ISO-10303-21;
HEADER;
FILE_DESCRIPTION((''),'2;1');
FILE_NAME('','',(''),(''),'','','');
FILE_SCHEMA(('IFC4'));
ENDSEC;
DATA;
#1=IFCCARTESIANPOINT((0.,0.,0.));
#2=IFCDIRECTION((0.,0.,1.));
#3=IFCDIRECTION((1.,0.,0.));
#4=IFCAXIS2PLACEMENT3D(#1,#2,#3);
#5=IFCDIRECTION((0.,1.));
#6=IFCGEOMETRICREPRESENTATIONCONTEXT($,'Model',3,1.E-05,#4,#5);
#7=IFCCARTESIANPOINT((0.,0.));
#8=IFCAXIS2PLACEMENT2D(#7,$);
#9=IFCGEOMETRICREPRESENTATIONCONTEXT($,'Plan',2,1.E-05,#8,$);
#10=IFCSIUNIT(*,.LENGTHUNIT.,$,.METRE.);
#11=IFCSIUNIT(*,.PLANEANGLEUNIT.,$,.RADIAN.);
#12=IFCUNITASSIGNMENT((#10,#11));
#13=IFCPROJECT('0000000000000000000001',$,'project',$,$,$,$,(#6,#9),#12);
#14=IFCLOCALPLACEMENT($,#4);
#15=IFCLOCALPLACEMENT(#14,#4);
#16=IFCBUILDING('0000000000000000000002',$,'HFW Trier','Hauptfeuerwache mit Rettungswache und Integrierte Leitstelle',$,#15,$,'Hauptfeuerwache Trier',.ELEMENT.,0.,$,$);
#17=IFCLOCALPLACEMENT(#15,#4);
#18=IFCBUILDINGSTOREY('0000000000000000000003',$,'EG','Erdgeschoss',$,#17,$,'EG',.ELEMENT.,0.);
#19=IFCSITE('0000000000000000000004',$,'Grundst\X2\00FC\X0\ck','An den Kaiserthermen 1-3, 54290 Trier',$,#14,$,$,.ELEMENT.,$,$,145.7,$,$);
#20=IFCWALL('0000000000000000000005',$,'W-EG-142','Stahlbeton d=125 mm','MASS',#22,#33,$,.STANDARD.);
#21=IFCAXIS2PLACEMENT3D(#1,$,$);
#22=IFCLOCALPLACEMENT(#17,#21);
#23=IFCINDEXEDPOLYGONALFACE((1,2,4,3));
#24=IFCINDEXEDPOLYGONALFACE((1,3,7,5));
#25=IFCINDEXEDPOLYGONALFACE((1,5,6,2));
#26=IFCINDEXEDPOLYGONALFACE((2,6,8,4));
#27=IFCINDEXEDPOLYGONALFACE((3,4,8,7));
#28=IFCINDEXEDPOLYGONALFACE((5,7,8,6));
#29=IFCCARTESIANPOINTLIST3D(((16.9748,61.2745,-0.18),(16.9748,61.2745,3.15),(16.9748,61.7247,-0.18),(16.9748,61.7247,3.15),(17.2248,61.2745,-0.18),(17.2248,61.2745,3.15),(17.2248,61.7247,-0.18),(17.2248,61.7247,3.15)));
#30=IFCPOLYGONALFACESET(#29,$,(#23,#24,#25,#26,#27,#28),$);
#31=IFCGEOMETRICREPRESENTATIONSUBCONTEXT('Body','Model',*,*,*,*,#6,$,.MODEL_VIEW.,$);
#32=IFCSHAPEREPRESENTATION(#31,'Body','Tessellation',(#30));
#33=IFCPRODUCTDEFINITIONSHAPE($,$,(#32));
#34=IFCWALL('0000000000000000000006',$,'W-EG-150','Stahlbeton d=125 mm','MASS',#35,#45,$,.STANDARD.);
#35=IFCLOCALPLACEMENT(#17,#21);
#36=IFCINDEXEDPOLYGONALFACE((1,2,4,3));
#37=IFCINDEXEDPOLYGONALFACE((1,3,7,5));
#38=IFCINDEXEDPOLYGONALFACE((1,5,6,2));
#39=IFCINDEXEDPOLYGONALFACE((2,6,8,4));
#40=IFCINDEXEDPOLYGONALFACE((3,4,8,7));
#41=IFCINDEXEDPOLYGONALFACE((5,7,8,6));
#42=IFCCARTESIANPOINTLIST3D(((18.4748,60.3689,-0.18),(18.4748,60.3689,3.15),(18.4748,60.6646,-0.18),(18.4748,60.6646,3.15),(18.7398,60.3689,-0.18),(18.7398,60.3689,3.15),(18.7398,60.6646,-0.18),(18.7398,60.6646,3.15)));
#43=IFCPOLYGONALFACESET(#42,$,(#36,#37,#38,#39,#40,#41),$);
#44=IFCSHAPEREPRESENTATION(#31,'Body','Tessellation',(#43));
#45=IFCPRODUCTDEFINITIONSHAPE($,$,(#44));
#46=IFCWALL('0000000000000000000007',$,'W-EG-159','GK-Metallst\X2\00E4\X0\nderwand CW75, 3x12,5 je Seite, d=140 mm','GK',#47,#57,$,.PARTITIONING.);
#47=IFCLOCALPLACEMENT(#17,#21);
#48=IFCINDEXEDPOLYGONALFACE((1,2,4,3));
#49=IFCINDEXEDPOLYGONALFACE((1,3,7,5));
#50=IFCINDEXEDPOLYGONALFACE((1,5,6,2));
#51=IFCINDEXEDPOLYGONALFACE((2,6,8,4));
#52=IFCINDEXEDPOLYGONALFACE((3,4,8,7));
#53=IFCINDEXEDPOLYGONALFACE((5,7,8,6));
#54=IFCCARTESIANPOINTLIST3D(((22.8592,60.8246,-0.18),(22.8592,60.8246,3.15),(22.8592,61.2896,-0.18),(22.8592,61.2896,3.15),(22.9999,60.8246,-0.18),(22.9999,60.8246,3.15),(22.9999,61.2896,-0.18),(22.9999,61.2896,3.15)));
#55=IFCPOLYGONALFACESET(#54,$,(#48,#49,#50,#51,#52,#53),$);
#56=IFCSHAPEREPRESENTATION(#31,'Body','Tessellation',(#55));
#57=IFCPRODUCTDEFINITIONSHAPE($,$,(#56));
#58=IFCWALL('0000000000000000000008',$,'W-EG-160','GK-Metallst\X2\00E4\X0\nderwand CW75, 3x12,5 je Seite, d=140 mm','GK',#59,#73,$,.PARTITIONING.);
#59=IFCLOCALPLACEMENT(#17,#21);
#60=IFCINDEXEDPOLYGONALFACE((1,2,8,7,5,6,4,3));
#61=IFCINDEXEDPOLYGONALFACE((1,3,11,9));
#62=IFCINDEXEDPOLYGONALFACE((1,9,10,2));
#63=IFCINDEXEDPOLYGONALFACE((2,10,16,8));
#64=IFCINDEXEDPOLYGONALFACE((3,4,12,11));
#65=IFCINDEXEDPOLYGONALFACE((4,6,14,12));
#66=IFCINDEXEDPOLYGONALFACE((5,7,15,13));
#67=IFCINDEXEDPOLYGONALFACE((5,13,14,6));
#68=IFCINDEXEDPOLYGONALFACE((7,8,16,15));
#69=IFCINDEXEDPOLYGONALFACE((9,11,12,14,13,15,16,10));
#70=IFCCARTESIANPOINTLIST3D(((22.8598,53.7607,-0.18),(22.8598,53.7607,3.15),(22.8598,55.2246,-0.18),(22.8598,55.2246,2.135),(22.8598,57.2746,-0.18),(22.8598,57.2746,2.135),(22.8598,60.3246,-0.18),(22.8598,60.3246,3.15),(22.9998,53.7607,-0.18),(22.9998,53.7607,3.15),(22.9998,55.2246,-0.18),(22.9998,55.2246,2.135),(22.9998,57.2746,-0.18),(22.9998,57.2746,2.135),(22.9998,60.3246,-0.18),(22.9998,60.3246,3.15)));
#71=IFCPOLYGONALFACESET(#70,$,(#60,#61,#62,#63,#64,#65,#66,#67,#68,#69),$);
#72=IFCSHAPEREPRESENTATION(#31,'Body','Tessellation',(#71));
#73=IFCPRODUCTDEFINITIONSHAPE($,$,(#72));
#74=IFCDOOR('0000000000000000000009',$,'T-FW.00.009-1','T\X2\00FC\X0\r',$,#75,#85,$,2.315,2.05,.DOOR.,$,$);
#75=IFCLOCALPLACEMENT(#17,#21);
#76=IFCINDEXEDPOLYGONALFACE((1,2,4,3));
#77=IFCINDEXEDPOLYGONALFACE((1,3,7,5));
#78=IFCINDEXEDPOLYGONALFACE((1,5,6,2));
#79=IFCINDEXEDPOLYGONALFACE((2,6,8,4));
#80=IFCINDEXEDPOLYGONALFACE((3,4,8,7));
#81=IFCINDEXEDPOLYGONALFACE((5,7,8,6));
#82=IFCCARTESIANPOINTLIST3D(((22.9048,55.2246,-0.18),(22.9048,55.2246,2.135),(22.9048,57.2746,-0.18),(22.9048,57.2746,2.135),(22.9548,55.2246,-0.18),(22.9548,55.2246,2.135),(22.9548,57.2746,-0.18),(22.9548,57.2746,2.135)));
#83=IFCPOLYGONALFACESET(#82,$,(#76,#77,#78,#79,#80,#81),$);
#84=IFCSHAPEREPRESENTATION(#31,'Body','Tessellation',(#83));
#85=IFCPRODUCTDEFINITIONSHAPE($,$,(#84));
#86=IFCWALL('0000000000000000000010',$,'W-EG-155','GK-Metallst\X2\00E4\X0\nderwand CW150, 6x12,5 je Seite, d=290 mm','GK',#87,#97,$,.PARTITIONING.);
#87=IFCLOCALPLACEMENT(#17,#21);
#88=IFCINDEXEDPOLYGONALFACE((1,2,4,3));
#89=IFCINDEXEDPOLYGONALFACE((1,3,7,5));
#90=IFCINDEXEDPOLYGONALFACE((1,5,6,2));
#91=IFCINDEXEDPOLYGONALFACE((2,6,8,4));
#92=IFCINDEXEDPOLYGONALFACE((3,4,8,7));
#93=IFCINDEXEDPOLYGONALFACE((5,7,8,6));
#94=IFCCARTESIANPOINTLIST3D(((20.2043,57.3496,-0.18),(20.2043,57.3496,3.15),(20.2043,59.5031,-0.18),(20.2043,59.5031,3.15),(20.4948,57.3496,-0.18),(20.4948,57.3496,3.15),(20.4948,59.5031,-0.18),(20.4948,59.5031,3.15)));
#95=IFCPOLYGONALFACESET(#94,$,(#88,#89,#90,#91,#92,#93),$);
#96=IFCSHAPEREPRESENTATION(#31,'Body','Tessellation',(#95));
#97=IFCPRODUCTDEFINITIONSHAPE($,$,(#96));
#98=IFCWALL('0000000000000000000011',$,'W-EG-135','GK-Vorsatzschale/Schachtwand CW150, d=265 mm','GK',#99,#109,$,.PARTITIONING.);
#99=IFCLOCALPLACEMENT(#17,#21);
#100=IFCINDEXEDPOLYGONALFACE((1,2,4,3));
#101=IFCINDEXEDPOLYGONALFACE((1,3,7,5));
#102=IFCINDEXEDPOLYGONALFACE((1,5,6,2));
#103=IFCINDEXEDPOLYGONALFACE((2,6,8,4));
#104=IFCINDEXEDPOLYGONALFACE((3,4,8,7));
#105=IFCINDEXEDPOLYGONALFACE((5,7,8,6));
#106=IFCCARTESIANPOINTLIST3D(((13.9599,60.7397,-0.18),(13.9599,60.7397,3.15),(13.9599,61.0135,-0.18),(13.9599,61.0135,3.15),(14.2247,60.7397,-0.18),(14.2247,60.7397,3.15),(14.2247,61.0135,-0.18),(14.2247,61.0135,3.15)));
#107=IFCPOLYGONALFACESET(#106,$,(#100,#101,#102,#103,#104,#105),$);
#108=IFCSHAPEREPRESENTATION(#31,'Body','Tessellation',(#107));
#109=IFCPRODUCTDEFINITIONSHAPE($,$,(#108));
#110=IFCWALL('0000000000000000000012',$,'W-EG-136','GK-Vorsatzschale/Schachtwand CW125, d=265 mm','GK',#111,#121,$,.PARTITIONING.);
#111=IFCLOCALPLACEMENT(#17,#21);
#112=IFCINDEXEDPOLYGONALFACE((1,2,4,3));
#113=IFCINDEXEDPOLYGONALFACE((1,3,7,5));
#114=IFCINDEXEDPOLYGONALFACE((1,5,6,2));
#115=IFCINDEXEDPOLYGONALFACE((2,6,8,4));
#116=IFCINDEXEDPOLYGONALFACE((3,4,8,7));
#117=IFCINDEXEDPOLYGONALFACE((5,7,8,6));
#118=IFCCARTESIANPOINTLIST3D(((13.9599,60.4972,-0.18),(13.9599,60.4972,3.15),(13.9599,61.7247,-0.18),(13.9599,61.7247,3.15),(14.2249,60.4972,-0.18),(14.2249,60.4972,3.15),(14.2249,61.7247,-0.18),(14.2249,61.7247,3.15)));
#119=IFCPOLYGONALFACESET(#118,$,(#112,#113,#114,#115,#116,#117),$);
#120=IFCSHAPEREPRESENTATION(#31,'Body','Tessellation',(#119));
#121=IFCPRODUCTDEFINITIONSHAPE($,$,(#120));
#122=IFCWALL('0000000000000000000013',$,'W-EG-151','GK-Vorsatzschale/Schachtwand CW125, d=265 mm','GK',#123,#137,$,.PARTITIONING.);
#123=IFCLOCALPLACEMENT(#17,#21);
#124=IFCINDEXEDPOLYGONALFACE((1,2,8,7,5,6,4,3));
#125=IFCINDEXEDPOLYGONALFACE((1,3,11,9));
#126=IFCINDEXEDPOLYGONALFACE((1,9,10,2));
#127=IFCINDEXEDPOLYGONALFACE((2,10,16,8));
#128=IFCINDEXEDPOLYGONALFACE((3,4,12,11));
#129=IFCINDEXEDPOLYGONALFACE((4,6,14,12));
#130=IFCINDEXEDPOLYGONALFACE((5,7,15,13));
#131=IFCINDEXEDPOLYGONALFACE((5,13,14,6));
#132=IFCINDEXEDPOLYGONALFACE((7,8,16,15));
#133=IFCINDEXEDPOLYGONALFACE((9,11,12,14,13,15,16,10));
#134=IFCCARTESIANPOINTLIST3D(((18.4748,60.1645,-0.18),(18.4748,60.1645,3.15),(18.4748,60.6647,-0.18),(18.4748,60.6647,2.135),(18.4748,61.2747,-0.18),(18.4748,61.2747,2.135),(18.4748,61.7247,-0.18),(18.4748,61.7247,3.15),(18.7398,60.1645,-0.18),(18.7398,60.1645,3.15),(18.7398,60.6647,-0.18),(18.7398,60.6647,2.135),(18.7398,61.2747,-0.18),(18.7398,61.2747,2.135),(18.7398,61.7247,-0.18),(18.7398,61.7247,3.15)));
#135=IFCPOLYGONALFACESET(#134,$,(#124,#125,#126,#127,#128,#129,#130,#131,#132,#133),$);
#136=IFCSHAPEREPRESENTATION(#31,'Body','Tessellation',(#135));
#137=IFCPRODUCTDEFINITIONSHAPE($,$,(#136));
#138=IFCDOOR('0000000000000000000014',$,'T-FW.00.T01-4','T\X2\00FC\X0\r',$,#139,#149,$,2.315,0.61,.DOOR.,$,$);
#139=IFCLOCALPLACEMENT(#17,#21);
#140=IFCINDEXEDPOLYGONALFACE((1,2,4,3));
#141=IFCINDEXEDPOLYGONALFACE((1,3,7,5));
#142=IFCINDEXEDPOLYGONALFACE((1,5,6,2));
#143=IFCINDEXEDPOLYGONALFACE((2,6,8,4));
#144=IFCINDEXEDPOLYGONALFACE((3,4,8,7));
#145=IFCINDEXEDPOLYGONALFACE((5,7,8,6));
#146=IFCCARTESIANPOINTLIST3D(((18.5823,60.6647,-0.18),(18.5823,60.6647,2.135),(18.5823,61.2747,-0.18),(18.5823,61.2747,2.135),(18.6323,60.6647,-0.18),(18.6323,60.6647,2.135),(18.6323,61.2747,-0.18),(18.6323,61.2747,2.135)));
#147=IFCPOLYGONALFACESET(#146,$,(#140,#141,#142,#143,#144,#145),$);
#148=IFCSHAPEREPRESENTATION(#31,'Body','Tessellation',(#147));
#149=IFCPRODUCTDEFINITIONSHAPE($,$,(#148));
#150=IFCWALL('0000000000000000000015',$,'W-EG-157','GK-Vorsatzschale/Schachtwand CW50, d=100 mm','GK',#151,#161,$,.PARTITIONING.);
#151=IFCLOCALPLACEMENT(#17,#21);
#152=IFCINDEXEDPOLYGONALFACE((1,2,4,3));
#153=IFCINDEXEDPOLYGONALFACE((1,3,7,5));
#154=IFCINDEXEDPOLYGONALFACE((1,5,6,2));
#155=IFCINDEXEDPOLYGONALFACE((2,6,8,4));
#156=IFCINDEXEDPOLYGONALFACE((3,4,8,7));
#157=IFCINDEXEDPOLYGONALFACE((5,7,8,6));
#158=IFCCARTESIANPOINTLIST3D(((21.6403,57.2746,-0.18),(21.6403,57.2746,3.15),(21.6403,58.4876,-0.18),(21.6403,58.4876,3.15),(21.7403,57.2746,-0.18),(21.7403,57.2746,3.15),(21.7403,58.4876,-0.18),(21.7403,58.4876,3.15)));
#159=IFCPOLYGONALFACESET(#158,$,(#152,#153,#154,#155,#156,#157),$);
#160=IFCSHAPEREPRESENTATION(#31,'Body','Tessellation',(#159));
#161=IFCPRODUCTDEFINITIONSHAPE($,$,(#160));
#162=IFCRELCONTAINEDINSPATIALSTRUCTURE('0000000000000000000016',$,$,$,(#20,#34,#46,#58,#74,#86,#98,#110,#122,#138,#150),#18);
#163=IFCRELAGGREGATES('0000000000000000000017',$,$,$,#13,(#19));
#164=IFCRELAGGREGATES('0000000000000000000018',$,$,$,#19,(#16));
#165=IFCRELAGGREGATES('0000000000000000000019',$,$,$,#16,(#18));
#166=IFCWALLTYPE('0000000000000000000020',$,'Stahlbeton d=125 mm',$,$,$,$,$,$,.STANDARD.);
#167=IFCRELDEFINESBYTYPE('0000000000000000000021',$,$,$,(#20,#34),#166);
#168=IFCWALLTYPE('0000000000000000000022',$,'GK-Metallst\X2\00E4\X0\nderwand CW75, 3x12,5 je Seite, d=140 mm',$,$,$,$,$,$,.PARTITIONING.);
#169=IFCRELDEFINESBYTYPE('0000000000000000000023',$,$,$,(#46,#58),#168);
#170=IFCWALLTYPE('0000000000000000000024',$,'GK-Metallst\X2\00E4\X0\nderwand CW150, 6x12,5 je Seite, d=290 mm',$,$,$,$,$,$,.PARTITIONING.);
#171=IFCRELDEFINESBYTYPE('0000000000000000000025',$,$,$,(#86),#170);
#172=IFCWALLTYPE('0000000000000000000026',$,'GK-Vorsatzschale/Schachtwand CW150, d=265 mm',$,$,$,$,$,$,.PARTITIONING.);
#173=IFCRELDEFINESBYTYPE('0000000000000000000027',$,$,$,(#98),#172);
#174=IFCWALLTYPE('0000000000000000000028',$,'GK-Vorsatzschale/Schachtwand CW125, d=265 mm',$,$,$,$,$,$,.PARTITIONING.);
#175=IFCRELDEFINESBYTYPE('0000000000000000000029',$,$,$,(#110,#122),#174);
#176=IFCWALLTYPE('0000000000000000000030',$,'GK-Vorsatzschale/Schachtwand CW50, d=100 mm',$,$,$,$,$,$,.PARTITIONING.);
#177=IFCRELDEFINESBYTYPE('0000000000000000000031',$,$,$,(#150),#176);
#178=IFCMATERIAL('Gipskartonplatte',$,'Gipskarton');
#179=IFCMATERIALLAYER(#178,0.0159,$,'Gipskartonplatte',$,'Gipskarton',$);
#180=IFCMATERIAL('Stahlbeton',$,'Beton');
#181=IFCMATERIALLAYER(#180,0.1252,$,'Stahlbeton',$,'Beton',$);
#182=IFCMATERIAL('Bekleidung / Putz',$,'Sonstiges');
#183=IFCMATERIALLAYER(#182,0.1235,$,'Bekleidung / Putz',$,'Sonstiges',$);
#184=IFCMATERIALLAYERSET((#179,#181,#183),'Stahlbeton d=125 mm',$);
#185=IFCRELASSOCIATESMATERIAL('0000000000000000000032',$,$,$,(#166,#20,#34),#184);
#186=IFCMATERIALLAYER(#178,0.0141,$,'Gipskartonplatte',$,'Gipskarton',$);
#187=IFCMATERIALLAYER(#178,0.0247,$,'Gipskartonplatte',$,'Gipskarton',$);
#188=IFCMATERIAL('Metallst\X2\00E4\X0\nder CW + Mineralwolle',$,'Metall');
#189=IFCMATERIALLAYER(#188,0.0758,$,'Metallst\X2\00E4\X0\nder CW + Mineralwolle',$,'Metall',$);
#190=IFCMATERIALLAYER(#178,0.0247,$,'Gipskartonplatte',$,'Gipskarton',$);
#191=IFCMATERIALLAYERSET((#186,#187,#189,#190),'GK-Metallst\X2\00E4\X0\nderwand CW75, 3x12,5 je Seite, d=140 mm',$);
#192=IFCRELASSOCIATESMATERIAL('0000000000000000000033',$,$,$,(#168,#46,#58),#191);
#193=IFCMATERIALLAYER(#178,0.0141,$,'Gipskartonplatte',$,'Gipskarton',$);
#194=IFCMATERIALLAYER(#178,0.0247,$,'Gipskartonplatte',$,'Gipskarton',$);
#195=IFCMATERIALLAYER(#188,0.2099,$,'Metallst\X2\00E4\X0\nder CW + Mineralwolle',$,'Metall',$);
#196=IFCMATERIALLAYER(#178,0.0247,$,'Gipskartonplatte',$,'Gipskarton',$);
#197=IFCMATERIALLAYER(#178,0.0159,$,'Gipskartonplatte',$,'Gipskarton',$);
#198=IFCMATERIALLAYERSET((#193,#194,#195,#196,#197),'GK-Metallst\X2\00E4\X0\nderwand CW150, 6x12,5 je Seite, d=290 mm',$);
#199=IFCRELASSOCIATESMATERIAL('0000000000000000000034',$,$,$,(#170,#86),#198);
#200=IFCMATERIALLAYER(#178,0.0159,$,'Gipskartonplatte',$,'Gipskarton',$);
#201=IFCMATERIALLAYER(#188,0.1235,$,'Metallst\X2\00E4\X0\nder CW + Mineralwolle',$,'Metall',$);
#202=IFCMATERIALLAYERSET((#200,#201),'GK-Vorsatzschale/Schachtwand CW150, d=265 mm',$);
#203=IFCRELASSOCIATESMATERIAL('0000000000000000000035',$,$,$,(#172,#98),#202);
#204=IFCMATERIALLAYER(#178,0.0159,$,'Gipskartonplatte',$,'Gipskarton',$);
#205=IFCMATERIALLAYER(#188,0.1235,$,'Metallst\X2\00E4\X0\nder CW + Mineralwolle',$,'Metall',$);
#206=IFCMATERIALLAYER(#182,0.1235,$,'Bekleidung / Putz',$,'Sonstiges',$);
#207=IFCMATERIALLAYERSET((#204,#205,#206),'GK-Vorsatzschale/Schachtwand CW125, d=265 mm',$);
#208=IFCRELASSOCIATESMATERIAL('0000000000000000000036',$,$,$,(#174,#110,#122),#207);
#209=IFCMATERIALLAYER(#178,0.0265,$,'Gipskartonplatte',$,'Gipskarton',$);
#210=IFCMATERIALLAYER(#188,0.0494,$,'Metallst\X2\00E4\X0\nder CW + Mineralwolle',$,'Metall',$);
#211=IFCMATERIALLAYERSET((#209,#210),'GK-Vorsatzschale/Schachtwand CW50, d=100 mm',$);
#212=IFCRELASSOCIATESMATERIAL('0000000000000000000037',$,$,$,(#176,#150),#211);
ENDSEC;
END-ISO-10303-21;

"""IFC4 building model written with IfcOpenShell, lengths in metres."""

from ifc_helpers import new_model, si_unit, direction, frame, frame_2d, origin_with_axes, origin_2d, place, context, subcontext, project, spatial, rectangle, extrude, material, layer, layer_set, layer_usage, type_object, element, fill, save


model = new_model("IFC4")

# Units and contexts
model_context = context("Model", 3, precision=1e-05, world=origin_with_axes(), true_north=direction((0.0, 1.0)))
plan_context = context("Plan", 2, precision=1e-05, world=origin_2d())
body_context = subcontext(model_context, "Body", "Model", "MODEL_VIEW")
ifc_project = project(units=[si_unit("LENGTHUNIT", "METRE"), si_unit("PLANEANGLEUNIT", "RADIAN")], contexts=[model_context, plan_context])

# Site, building, storey
site_placement = place(None, origin_with_axes())
site = spatial("IfcSite", under=ifc_project, at=site_placement, Name="Grundstück", Description="An den Kaiserthermen 1-3, 54290 Trier", CompositionType="ELEMENT", RefElevation=145.7)
building_placement = place(site_placement, origin_with_axes())
building = spatial("IfcBuilding", under=site, at=building_placement, Name="HFW Trier", Description="Hauptfeuerwache mit Rettungswache und Integrierte Leitstelle", LongName="Hauptfeuerwache Trier", CompositionType="ELEMENT", ElevationOfRefHeight=0.0)
storey_placement = place(building_placement, origin_with_axes())
storey = spatial("IfcBuildingStorey", under=building, at=storey_placement, Name="EG", Description="Erdgeschoss", LongName="EG", CompositionType="ELEMENT", Elevation=0.0)

# Shared definitions
ifc_material_1 = material(Name="Stahlbeton", Category="Beton")

# Walls
ifc_material_2 = material(Name="Metallständer CW + Mineralwolle", Category="Metall")
ifc_material_3 = material(Name="Gipskartonplatte", Category="Gipskarton")
ifc_layer_1 = layer(ifc_material_3, 0.0159, Name="Gipskartonplatte", Category="Gipskarton")
ifc_layer_2 = layer(ifc_material_1, 0.1252, Name="Stahlbeton", Category="Beton")
ifc_material_4 = material(Name="Bekleidung / Putz", Category="Sonstiges")
ifc_layer_3 = layer(ifc_material_4, 0.1235, Name="Bekleidung / Putz", Category="Sonstiges")
ifc_layer_set_1 = layer_set([ifc_layer_1, ifc_layer_2, ifc_layer_3], Name="Stahlbeton d=125 mm")
ifc_layer_usage_1 = layer_usage(ifc_layer_set_1, "AXIS2", "POSITIVE", -0.125)
wall_type_1 = type_object("IfcWallType", Name="Stahlbeton d=125 mm", PredefinedType="STANDARD", material=ifc_layer_set_1)
wall_1_placement = place(storey_placement, frame((17.0998, 61.7247, -0.18), z_axis=(0.0, 0.0, 1.0), x_axis=(0.0, -1.0, 0.0)))
element("IfcWall", 1, at=wall_1_placement, inside=storey, type_object=wall_type_1, material=ifc_layer_usage_1, Name="W-EG-142", Description="Stahlbeton d=125 mm", ObjectType="MASS", PredefinedType="STANDARD", context=body_context, shape_type="SweptSolid", body=[
    extrude(rectangle(XDim=0.4502, YDim=0.25, at=frame_2d((0.2251, 0.0))), origin_with_axes(), (0.0, 0.0, 1.0), 3.33),
])
ifc_layer_usage_2 = layer_usage(ifc_layer_set_1, "AXIS2", "POSITIVE", -0.1325)
wall_2_placement = place(storey_placement, frame((18.6073, 60.6646, -0.18), z_axis=(0.0, 0.0, 1.0), x_axis=(0.0, -1.0, 0.0)))
element("IfcWall", 2, at=wall_2_placement, inside=storey, type_object=wall_type_1, material=ifc_layer_usage_2, Name="W-EG-150", Description="Stahlbeton d=125 mm", ObjectType="MASS", PredefinedType="STANDARD", context=body_context, shape_type="SweptSolid", body=[
    extrude(rectangle(XDim=0.2957, YDim=0.265, at=frame_2d((0.1479, 0.0))), origin_with_axes(), (0.0, 0.0, 1.0), 3.33),
])
ifc_layer_4 = layer(ifc_material_3, 0.0141, Name="Gipskartonplatte", Category="Gipskarton")
ifc_layer_5 = layer(ifc_material_3, 0.0247, Name="Gipskartonplatte", Category="Gipskarton")
ifc_layer_6 = layer(ifc_material_2, 0.0758, Name="Metallständer CW + Mineralwolle", Category="Metall")
ifc_layer_7 = layer(ifc_material_3, 0.0247, Name="Gipskartonplatte", Category="Gipskarton")
ifc_layer_set_2 = layer_set([ifc_layer_4, ifc_layer_5, ifc_layer_6, ifc_layer_7], Name="GK-Metallständerwand CW75, 3x12,5 je Seite, d=140 mm")
ifc_layer_usage_3 = layer_usage(ifc_layer_set_2, "AXIS2", "POSITIVE", -0.0703)
wall_type_2 = type_object("IfcWallType", Name="GK-Metallständerwand CW75, 3x12,5 je Seite, d=140 mm", PredefinedType="PARTITIONING", material=ifc_layer_set_2)
wall_3_placement = place(storey_placement, frame((22.9295, 61.2896, -0.18), z_axis=(0.0, 0.0, 1.0), x_axis=(0.0, -1.0, 0.0)))
element("IfcWall", 3, at=wall_3_placement, inside=storey, type_object=wall_type_2, material=ifc_layer_usage_3, Name="W-EG-159", Description="GK-Metallständerwand CW75, 3x12,5 je Seite, d=140 mm", ObjectType="GK", PredefinedType="PARTITIONING", context=body_context, shape_type="SweptSolid", body=[
    extrude(rectangle(XDim=0.465, YDim=0.1407, at=frame_2d((0.2325, 0.0))), origin_with_axes(), (0.0, 0.0, 1.0), 3.33),
])

# Wall, opening, door
ifc_layer_usage_4 = layer_usage(ifc_layer_set_2, "AXIS2", "POSITIVE", -0.07)
wall_4_placement = place(storey_placement, frame((22.9298, 60.3246, -0.18), z_axis=(0.0, 0.0, 1.0), x_axis=(0.0, -1.0, 0.0)))
wall_4 = element("IfcWall", 4, at=wall_4_placement, inside=storey, type_object=wall_type_2, material=ifc_layer_usage_4, Name="W-EG-160", Description="GK-Metallständerwand CW75, 3x12,5 je Seite, d=140 mm", ObjectType="GK", PredefinedType="PARTITIONING", context=body_context, shape_type="SweptSolid", body=[
    extrude(rectangle(XDim=6.5639, YDim=0.14, at=frame_2d((3.2819, 0.0))), origin_with_axes(), (0.0, 0.0, 1.0), 3.33),
])
opening_1_placement = place(wall_4_placement, frame((3.05, 0.0, 0.0), z_axis=(0.0, 0.0, 1.0), x_axis=(1.0, 0.0, 0.0)))
opening_1 = element("IfcOpeningElement", 5, at=opening_1_placement, cuts=wall_4, PredefinedType="OPENING", context=body_context, shape_type="SweptSolid", body=[
    extrude(rectangle(XDim=2.05, YDim=0.24, at=frame_2d((1.025, 0.0))), origin_with_axes(), (0.0, 0.0, 1.0), 2.315),
])
door_1_placement = place(wall_4_placement, frame((3.05, 0.0, 0.0), z_axis=(0.0, 0.0, 1.0), x_axis=(1.0, 0.0, 0.0)))
door_1 = element("IfcDoor", 6, at=door_1_placement, inside=storey, Name="T-FW.00.009-1", Description="Tür", OverallHeight=2.315, OverallWidth=2.05, PredefinedType="DOOR", context=body_context, shape_type="SweptSolid", body=[
    extrude(rectangle(XDim=2.05, YDim=0.05, at=frame_2d((1.025, 0.0))), origin_with_axes(), (0.0, 0.0, 1.0), 2.315),
])
fill(opening_1, door_1)

# Walls
ifc_layer_8 = layer(ifc_material_3, 0.0141, Name="Gipskartonplatte", Category="Gipskarton")
ifc_layer_9 = layer(ifc_material_3, 0.0247, Name="Gipskartonplatte", Category="Gipskarton")
ifc_layer_10 = layer(ifc_material_2, 0.2099, Name="Metallständer CW + Mineralwolle", Category="Metall")
ifc_layer_11 = layer(ifc_material_3, 0.0247, Name="Gipskartonplatte", Category="Gipskarton")
ifc_layer_12 = layer(ifc_material_3, 0.0159, Name="Gipskartonplatte", Category="Gipskarton")
ifc_layer_set_3 = layer_set([ifc_layer_8, ifc_layer_9, ifc_layer_10, ifc_layer_11, ifc_layer_12], Name="GK-Metallständerwand CW150, 6x12,5 je Seite, d=290 mm")
ifc_layer_usage_5 = layer_usage(ifc_layer_set_3, "AXIS2", "POSITIVE", -0.1452)
wall_type_3 = type_object("IfcWallType", Name="GK-Metallständerwand CW150, 6x12,5 je Seite, d=290 mm", PredefinedType="PARTITIONING", material=ifc_layer_set_3)
wall_5_placement = place(storey_placement, frame((20.3496, 59.5031, -0.18), z_axis=(0.0, 0.0, 1.0), x_axis=(0.0, -1.0, 0.0)))
element("IfcWall", 7, at=wall_5_placement, inside=storey, type_object=wall_type_3, material=ifc_layer_usage_5, Name="W-EG-155", Description="GK-Metallständerwand CW150, 6x12,5 je Seite, d=290 mm", ObjectType="GK", PredefinedType="PARTITIONING", context=body_context, shape_type="SweptSolid", body=[
    extrude(rectangle(XDim=2.1535, YDim=0.2905, at=frame_2d((1.0768, 0.0))), origin_with_axes(), (0.0, 0.0, 1.0), 3.33),
])
ifc_layer_13 = layer(ifc_material_3, 0.0159, Name="Gipskartonplatte", Category="Gipskarton")
ifc_layer_14 = layer(ifc_material_2, 0.1235, Name="Metallständer CW + Mineralwolle", Category="Metall")
ifc_layer_set_4 = layer_set([ifc_layer_13, ifc_layer_14], Name="GK-Vorsatzschale/Schachtwand CW150, d=265 mm")
ifc_layer_usage_6 = layer_usage(ifc_layer_set_4, "AXIS2", "POSITIVE", -0.1324)
wall_type_4 = type_object("IfcWallType", Name="GK-Vorsatzschale/Schachtwand CW150, d=265 mm", PredefinedType="PARTITIONING", material=ifc_layer_set_4)
wall_6_placement = place(storey_placement, frame((14.0923, 61.0135, -0.18), z_axis=(0.0, 0.0, 1.0), x_axis=(0.0, -1.0, 0.0)))
element("IfcWall", 8, at=wall_6_placement, inside=storey, type_object=wall_type_4, material=ifc_layer_usage_6, Name="W-EG-135", Description="GK-Vorsatzschale/Schachtwand CW150, d=265 mm", ObjectType="GK", PredefinedType="PARTITIONING", context=body_context, shape_type="SweptSolid", body=[
    extrude(rectangle(XDim=0.2738, YDim=0.2648, at=frame_2d((0.1369, 0.0))), origin_with_axes(), (0.0, 0.0, 1.0), 3.33),
])
ifc_layer_15 = layer(ifc_material_3, 0.0159, Name="Gipskartonplatte", Category="Gipskarton")
ifc_layer_16 = layer(ifc_material_2, 0.1235, Name="Metallständer CW + Mineralwolle", Category="Metall")
ifc_layer_17 = layer(ifc_material_4, 0.1235, Name="Bekleidung / Putz", Category="Sonstiges")
ifc_layer_set_5 = layer_set([ifc_layer_15, ifc_layer_16, ifc_layer_17], Name="GK-Vorsatzschale/Schachtwand CW125, d=265 mm")
ifc_layer_usage_7 = layer_usage(ifc_layer_set_5, "AXIS2", "POSITIVE", -0.1325)
wall_type_5 = type_object("IfcWallType", Name="GK-Vorsatzschale/Schachtwand CW125, d=265 mm", PredefinedType="PARTITIONING", material=ifc_layer_set_5)
wall_7_placement = place(storey_placement, frame((14.0924, 61.7247, -0.18), z_axis=(0.0, 0.0, 1.0), x_axis=(0.0, -1.0, 0.0)))
element("IfcWall", 9, at=wall_7_placement, inside=storey, type_object=wall_type_5, material=ifc_layer_usage_7, Name="W-EG-136", Description="GK-Vorsatzschale/Schachtwand CW125, d=265 mm", ObjectType="GK", PredefinedType="PARTITIONING", context=body_context, shape_type="SweptSolid", body=[
    extrude(rectangle(XDim=1.2275, YDim=0.265, at=frame_2d((0.6137, 0.0))), origin_with_axes(), (0.0, 0.0, 1.0), 3.33),
])

# Wall, opening, door
ifc_layer_usage_8 = layer_usage(ifc_layer_set_5, "AXIS2", "POSITIVE", -0.1325)
wall_8_placement = place(storey_placement, frame((18.6073, 61.7247, -0.18), z_axis=(0.0, 0.0, 1.0), x_axis=(0.0, -1.0, 0.0)))
wall_8 = element("IfcWall", 10, at=wall_8_placement, inside=storey, type_object=wall_type_5, material=ifc_layer_usage_8, Name="W-EG-151", Description="GK-Vorsatzschale/Schachtwand CW125, d=265 mm", ObjectType="GK", PredefinedType="PARTITIONING", context=body_context, shape_type="SweptSolid", body=[
    extrude(rectangle(XDim=1.5602, YDim=0.265, at=frame_2d((0.7801, 0.0))), origin_with_axes(), (0.0, 0.0, 1.0), 3.33),
])
opening_2_placement = place(wall_8_placement, frame((0.45, 0.0, 0.0), z_axis=(0.0, 0.0, 1.0), x_axis=(1.0, 0.0, 0.0)))
opening_2 = element("IfcOpeningElement", 11, at=opening_2_placement, cuts=wall_8, PredefinedType="OPENING", context=body_context, shape_type="SweptSolid", body=[
    extrude(rectangle(XDim=0.61, YDim=0.365, at=frame_2d((0.305, 0.0))), origin_with_axes(), (0.0, 0.0, 1.0), 2.315),
])
door_2_placement = place(wall_8_placement, frame((0.45, 0.0, 0.0), z_axis=(0.0, 0.0, 1.0), x_axis=(1.0, 0.0, 0.0)))
door_2 = element("IfcDoor", 12, at=door_2_placement, inside=storey, Name="T-FW.00.T01-4", Description="Tür", OverallHeight=2.315, OverallWidth=0.61, PredefinedType="DOOR", context=body_context, shape_type="SweptSolid", body=[
    extrude(rectangle(XDim=0.61, YDim=0.05, at=frame_2d((0.305, 0.0))), origin_with_axes(), (0.0, 0.0, 1.0), 2.315),
])
fill(opening_2, door_2)

# Wall
ifc_layer_18 = layer(ifc_material_3, 0.0265, Name="Gipskartonplatte", Category="Gipskarton")
ifc_layer_19 = layer(ifc_material_2, 0.0494, Name="Metallständer CW + Mineralwolle", Category="Metall")
ifc_layer_set_6 = layer_set([ifc_layer_18, ifc_layer_19], Name="GK-Vorsatzschale/Schachtwand CW50, d=100 mm")
ifc_layer_usage_9 = layer_usage(ifc_layer_set_6, "AXIS2", "POSITIVE", -0.05)
wall_type_6 = type_object("IfcWallType", Name="GK-Vorsatzschale/Schachtwand CW50, d=100 mm", PredefinedType="PARTITIONING", material=ifc_layer_set_6)
wall_9_placement = place(storey_placement, frame((21.6903, 58.4876, -0.18), z_axis=(0.0, 0.0, 1.0), x_axis=(0.0, -1.0, 0.0)))
element("IfcWall", 13, at=wall_9_placement, inside=storey, type_object=wall_type_6, material=ifc_layer_usage_9, Name="W-EG-157", Description="GK-Vorsatzschale/Schachtwand CW50, d=100 mm", ObjectType="GK", PredefinedType="PARTITIONING", context=body_context, shape_type="SweptSolid", body=[
    extrude(rectangle(XDim=1.213, YDim=0.1, at=frame_2d((0.6065, 0.0))), origin_with_axes(), (0.0, 0.0, 1.0), 3.33),
])

save(model, "model.ifc")
